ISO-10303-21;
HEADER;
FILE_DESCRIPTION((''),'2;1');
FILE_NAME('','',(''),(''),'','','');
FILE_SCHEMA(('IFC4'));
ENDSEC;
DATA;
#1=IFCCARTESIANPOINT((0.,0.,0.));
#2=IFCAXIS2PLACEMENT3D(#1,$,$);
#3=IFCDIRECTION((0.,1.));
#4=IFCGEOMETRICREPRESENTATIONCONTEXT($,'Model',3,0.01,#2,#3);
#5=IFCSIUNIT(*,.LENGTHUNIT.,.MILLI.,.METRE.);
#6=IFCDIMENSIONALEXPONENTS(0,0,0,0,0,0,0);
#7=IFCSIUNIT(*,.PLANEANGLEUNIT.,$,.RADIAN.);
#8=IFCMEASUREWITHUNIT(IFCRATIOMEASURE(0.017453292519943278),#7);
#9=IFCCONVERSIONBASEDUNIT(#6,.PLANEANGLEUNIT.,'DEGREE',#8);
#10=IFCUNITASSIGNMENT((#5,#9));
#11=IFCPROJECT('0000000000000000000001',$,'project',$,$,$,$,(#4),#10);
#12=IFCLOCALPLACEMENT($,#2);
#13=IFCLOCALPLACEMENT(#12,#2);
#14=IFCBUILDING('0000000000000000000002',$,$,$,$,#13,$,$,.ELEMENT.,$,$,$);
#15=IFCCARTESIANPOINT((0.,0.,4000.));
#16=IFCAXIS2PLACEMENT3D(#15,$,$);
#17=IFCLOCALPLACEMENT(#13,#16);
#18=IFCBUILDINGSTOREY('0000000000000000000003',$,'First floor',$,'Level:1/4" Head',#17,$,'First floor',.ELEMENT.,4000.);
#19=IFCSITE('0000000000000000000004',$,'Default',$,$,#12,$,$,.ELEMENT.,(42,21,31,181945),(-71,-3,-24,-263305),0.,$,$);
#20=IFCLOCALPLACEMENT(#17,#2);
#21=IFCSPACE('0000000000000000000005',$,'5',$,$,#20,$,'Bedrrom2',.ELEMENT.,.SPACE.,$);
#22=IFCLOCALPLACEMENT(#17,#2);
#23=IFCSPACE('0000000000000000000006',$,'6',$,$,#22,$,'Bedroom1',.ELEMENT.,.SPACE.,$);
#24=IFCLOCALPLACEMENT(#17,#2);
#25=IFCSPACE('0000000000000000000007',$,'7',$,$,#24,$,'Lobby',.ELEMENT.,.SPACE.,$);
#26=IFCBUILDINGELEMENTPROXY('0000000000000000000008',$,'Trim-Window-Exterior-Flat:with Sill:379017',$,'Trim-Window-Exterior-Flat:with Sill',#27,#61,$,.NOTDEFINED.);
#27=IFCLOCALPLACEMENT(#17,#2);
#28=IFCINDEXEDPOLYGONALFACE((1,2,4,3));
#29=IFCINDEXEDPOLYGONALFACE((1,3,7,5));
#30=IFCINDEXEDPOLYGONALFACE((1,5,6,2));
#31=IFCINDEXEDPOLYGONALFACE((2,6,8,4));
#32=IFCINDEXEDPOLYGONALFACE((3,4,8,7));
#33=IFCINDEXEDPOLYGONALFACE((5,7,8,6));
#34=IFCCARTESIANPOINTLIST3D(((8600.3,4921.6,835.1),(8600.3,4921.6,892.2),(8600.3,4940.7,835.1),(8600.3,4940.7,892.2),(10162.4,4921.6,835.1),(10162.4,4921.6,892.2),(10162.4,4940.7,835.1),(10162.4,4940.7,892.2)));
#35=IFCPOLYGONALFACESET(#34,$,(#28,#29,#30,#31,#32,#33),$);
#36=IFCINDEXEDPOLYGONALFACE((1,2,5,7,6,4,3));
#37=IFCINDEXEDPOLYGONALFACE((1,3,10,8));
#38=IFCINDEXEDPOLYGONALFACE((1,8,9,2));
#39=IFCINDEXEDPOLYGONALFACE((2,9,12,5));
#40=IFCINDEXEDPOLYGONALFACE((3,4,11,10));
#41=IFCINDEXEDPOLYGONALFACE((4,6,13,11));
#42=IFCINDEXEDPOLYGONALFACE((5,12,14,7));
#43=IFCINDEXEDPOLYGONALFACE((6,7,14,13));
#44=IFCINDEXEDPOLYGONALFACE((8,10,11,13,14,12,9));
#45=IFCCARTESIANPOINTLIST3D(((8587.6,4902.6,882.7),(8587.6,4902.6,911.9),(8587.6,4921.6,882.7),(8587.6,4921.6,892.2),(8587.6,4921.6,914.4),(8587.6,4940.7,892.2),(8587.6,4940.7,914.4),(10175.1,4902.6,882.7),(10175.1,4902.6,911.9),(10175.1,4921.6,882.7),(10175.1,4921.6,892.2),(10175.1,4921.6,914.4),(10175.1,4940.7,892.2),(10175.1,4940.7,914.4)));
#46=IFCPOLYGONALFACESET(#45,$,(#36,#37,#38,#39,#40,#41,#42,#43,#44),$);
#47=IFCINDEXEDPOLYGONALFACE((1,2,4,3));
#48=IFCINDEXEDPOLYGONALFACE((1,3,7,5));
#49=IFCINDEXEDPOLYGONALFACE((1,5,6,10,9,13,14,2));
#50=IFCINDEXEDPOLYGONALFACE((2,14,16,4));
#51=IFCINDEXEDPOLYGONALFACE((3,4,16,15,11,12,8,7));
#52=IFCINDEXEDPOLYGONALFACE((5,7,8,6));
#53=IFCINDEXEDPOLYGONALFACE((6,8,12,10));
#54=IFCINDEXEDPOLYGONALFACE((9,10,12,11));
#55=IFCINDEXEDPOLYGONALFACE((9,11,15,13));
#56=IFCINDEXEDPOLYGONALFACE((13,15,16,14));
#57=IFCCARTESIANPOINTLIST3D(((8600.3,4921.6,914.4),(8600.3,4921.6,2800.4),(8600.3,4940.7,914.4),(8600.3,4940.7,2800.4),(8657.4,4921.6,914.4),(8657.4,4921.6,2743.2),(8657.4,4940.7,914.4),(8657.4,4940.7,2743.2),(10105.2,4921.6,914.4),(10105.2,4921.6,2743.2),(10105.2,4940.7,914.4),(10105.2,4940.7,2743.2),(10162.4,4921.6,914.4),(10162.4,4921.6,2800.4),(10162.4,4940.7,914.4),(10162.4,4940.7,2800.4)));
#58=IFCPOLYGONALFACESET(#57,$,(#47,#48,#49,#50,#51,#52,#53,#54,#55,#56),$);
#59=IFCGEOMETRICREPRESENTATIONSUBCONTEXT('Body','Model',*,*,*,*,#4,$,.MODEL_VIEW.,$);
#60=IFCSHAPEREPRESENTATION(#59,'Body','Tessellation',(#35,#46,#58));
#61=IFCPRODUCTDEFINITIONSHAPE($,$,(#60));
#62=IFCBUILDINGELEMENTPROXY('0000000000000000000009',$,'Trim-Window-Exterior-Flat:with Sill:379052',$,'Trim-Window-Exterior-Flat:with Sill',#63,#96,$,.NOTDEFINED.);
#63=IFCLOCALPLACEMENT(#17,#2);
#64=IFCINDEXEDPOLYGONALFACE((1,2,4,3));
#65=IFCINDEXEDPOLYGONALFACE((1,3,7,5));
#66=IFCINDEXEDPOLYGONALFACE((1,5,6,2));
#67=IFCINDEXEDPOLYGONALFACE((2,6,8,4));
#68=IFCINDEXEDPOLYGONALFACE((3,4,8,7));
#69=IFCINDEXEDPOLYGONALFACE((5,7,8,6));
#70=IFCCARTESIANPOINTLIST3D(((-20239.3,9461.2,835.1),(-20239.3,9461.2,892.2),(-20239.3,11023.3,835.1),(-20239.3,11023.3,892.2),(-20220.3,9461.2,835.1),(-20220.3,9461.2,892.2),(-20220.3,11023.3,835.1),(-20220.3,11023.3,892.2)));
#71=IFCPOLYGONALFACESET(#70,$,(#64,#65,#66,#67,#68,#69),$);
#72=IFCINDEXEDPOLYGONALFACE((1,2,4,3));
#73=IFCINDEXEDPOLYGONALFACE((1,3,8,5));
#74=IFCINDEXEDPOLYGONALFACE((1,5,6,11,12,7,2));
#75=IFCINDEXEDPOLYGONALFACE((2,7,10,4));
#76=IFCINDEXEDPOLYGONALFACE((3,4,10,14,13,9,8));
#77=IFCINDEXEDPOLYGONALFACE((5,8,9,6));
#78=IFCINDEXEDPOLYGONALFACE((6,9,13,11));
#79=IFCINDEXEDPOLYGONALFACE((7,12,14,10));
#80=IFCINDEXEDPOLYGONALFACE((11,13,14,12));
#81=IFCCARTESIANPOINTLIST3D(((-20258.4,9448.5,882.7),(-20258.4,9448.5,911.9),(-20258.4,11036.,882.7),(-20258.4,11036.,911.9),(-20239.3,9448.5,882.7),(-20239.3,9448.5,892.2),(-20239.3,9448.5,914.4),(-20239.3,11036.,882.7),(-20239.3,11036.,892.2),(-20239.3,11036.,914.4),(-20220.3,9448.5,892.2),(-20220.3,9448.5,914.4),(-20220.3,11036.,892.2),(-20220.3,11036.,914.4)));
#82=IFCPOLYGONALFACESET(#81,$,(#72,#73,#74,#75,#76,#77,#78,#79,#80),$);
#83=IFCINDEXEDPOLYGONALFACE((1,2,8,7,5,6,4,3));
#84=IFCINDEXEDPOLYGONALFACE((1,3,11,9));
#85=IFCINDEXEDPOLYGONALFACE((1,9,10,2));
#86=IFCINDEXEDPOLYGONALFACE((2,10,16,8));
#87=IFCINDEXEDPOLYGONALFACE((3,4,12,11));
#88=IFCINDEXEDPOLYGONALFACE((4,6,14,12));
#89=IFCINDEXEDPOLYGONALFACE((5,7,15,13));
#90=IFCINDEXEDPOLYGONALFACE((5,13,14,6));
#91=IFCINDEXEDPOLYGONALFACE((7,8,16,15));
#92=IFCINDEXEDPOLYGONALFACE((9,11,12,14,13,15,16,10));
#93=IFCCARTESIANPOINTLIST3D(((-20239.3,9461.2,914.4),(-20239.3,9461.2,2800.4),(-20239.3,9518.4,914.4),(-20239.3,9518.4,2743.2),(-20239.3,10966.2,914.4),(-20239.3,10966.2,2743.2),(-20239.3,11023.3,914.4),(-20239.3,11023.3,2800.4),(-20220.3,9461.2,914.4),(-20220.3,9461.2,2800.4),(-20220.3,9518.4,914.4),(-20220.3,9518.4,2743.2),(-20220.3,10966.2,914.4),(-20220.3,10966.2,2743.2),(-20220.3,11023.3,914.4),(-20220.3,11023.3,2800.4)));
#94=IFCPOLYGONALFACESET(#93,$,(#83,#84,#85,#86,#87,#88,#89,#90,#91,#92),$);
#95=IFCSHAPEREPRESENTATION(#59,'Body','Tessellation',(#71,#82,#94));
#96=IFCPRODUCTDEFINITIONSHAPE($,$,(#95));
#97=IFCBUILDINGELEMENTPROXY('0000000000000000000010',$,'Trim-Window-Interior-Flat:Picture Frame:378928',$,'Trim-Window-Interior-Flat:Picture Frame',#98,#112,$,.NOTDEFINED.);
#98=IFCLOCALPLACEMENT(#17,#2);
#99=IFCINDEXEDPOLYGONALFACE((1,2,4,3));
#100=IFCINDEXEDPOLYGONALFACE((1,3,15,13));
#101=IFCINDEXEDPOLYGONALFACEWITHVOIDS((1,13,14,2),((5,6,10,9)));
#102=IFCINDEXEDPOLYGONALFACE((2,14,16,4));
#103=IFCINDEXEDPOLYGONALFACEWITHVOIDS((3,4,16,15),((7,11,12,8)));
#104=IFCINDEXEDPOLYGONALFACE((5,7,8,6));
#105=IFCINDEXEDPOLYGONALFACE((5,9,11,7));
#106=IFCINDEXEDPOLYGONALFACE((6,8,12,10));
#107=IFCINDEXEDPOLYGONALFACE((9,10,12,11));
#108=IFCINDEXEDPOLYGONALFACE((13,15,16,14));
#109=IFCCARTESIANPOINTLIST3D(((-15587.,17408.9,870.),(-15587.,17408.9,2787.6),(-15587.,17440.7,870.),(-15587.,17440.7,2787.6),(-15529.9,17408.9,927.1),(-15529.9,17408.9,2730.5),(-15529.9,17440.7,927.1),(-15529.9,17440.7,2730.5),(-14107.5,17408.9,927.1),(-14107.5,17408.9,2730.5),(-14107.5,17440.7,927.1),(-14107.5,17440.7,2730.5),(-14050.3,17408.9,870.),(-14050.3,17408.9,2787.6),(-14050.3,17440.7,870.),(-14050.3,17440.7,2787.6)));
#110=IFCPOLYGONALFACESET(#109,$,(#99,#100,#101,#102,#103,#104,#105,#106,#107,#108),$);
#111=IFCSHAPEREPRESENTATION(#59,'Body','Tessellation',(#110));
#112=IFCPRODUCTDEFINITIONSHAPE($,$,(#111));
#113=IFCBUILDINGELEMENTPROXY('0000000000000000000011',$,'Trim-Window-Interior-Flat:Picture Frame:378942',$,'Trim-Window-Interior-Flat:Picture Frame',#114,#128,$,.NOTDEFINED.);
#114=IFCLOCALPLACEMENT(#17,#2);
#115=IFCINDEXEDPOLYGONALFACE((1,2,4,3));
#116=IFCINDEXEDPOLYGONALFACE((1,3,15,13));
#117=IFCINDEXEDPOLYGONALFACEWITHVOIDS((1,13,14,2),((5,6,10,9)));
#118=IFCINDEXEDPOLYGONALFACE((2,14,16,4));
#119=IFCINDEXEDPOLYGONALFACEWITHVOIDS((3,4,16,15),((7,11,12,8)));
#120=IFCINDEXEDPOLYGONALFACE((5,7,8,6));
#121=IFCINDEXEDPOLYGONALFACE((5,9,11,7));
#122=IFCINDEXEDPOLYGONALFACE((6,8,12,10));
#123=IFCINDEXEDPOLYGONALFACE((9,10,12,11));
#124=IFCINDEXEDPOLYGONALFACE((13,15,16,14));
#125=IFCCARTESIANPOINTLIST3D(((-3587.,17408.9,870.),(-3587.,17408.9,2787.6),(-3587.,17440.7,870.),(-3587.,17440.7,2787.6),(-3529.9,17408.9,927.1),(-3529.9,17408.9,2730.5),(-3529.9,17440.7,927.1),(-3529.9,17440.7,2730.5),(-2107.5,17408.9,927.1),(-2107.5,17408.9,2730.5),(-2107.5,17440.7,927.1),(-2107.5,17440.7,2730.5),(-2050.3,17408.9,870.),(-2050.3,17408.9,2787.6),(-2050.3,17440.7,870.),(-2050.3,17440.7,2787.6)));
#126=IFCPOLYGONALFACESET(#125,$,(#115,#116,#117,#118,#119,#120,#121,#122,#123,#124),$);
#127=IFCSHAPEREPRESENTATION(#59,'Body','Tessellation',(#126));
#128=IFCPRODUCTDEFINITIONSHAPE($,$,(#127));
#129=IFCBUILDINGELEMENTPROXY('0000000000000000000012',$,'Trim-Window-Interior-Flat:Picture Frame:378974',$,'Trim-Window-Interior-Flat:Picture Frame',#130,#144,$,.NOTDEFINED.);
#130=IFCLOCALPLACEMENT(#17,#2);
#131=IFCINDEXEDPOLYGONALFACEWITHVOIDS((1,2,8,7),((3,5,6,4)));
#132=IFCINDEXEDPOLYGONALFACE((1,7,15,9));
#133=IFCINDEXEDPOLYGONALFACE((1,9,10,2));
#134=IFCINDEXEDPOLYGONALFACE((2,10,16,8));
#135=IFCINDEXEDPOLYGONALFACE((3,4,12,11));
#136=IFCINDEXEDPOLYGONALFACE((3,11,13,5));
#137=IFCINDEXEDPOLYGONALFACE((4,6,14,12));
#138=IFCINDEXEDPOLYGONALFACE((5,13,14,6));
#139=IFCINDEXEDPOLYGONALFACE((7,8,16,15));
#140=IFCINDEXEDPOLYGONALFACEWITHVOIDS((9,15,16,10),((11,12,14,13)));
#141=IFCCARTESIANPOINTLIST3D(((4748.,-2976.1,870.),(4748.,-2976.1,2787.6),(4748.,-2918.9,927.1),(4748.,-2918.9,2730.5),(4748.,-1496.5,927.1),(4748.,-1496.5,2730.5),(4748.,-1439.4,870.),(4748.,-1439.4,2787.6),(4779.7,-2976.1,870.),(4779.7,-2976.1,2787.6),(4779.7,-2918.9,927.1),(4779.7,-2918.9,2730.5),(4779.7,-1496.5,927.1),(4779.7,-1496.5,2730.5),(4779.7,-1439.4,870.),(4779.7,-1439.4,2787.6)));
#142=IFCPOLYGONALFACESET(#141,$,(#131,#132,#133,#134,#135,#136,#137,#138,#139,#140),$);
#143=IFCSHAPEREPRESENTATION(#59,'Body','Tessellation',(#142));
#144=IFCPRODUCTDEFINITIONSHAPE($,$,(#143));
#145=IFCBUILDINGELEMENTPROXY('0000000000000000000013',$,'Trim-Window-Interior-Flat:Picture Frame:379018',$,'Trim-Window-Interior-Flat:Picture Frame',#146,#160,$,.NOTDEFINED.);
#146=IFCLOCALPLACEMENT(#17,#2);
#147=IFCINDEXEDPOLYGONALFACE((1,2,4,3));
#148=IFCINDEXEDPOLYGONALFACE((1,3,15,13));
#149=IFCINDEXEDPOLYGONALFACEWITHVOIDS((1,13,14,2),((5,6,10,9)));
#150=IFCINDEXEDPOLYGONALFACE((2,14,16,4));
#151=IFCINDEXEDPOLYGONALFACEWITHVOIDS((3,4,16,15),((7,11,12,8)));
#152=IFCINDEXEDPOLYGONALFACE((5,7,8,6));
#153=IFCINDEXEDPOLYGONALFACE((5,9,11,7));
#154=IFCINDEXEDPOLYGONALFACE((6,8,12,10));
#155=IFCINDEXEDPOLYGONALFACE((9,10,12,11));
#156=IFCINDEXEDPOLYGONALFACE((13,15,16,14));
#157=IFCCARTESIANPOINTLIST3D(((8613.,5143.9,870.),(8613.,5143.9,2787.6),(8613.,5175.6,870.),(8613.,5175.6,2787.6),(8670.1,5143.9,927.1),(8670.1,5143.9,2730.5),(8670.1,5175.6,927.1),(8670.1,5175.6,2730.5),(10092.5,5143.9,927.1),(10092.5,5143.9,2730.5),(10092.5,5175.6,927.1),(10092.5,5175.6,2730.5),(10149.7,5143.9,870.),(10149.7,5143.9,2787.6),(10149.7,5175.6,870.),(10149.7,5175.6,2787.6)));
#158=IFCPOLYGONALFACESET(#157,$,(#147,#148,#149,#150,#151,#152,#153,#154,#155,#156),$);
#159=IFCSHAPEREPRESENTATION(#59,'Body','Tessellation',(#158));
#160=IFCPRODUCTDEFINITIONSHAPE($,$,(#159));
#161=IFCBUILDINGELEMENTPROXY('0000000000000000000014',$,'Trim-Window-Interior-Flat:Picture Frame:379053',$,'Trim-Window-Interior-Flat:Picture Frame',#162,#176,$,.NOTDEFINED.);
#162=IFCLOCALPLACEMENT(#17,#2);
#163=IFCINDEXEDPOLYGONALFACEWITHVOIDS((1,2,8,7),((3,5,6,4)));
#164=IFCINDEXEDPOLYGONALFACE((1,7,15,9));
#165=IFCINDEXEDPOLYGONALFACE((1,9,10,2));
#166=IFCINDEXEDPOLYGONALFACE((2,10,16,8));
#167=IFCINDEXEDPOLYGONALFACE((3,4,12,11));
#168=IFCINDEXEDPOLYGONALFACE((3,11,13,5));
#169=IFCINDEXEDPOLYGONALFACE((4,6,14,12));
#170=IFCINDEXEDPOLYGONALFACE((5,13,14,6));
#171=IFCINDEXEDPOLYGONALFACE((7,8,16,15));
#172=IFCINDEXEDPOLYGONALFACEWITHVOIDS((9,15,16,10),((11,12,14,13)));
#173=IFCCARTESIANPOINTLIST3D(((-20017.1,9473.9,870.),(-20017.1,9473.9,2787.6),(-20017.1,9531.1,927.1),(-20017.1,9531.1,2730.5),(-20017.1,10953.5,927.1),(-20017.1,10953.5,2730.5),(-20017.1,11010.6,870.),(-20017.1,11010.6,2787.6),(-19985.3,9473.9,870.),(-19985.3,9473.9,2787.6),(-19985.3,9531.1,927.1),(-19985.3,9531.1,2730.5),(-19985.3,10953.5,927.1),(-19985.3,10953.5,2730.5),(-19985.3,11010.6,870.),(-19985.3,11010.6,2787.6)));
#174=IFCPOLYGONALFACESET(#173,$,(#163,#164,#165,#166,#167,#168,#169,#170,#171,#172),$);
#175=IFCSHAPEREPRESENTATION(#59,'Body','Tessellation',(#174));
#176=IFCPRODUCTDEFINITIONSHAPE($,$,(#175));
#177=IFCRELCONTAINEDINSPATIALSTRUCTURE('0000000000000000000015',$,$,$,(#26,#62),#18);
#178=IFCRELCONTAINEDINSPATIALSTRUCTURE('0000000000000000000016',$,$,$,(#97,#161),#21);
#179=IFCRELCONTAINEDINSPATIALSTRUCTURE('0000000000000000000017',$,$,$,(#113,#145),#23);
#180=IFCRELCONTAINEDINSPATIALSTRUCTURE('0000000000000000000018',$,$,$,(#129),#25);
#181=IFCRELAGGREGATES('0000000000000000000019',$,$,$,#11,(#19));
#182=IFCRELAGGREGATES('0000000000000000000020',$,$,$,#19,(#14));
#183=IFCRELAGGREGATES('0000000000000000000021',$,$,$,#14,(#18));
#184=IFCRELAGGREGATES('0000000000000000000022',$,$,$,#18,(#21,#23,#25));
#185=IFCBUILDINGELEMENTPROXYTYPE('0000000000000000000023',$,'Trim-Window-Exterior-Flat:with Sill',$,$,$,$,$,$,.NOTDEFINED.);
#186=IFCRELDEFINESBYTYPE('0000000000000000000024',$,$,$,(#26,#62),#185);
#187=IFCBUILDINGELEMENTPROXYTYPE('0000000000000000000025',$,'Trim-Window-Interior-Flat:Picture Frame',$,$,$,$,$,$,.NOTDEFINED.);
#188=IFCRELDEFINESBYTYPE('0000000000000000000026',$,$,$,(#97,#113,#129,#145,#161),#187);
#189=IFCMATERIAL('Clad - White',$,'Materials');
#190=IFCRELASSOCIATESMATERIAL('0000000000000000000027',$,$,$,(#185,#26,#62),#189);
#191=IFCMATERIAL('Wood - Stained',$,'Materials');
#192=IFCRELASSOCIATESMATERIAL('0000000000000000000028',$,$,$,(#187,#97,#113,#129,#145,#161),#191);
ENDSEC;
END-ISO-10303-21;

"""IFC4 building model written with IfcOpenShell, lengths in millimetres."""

from ifc_helpers import new_model, entity, si_unit, converted_unit, direction, frame, origin, place, context, subcontext, project, spatial, indexed_curve, outline, extrude, source, transform, mapped, material, type_object, type_shapes, element, save


model = new_model("IFC4")

# Units and contexts
model_context = context("Model", 3, precision=0.01, world=origin(), true_north=direction((0.0, 1.0)))
body_context = subcontext(model_context, "Body", "Model", "MODEL_VIEW")
ifc_project = project(units=[si_unit("LENGTHUNIT", "METRE", prefix="MILLI"), converted_unit("PLANEANGLEUNIT", "DEGREE", entity("IfcRatioMeasure", 0.017453292519943278), si_unit("PLANEANGLEUNIT", "RADIAN"), dimensions=[0, 0, 0, 0, 0, 0, 0])], contexts=[model_context])

# Site, building, storey
site_placement = place(None, origin())
site = spatial("IfcSite", under=ifc_project, at=site_placement, Name="Default", CompositionType="ELEMENT", RefLatitude=(42, 21, 31, 181945), RefLongitude=(-71, -3, -24, -263305), RefElevation=0.0)
building_placement = place(site_placement, origin())
building = spatial("IfcBuilding", under=site, at=building_placement, CompositionType="ELEMENT")
storey_placement = place(building_placement, frame((0.0, 0.0, 4000.0)))
storey = spatial("IfcBuildingStorey", under=building, at=storey_placement, Name="First floor", ObjectType="Level:1/4\" Head", LongName="First floor", CompositionType="ELEMENT", Elevation=4000.0)

# Building element proxies
ifc_material_1 = material(Name="Clad - White", Category="Materials")
ifc_material_2 = material(Name="Wood - Stained", Category="Materials")
building_element_proxy_type_1 = type_object("IfcBuildingElementProxyType", Name="Trim-Window-Exterior-Flat:with Sill", PredefinedType="NOTDEFINED", material=ifc_material_1)
shared_shape_1 = source(origin(), body_context, "Body", "SweptSolid", [
    extrude(outline(indexed_curve([(-781.0, -28.6), (781.0, -28.6), (781.0, 28.6), (-781.0, 28.6), (-781.0, -28.6)], self_intersect=False)), frame((0.0, -1879.6, 0.0), z_axis=(0.0, 0.0, 1.0), x_axis=(-1.0, 0.0, 0.0)), (0.0, 0.0, 1.0), 19.0),
    extrude(outline(indexed_curve([(-19.0, -16.0), (0.0, -16.0), (0.0, -6.4), (19.0, -6.4), (19.0, 15.8), (0.0, 15.8), (-19.0, 13.3), (-19.0, -16.0)], self_intersect=False)), frame((-793.7, -1844.6, 19.0), z_axis=(1.0, 0.0, 0.0), x_axis=(0.0, 0.0, -1.0)), (0.0, 0.0, 1.0), 1587.5),
    extrude(outline(indexed_curve([(-957.3, -781.0), (928.7, -781.0), (928.7, -723.9), (-900.1, -723.9), (-900.1, 723.9), (928.7, 723.9), (928.7, 781.0), (-957.3, 781.0), (-957.3, -781.0)], self_intersect=False)), frame((0.0, -900.1, 0.0), z_axis=(0.0, 0.0, 1.0), x_axis=(0.0, -1.0, 0.0)), (0.0, 0.0, 1.0), 19.0),
])
type_shapes(building_element_proxy_type_1, [shared_shape_1])
for number, where, z_axis, x_axis, name in (
    (1, (9381.3, 4940.7, 2743.2), (0.0, -1.0, 0.0), (1.0, 0.0, 0.0), "Trim-Window-Exterior-Flat:with Sill:379017"),
    (2, (-20220.3, 10242.3, 2743.2), (-1.0, 0.0, 0.0), (0.0, -1.0, 0.0), "Trim-Window-Exterior-Flat:with Sill:379052"),
):
    element("IfcBuildingElementProxy", number, at=place(storey_placement, frame(where, z_axis=z_axis, x_axis=x_axis)), inside=storey, type_object=building_element_proxy_type_1, material=ifc_material_1, Name=name, ObjectType="Trim-Window-Exterior-Flat:with Sill", PredefinedType="NOTDEFINED", context=body_context, shape_type="MappedRepresentation", body=[
        mapped(shared_shape_1, transform((0.0, 0.0, 0.0), scale=1.0)),
    ])

# Shared definitions
space_1_placement = place(storey_placement, origin())
space_1 = spatial("IfcSpace", under=storey, at=space_1_placement, Name="5", LongName="Bedrrom2", CompositionType="ELEMENT", PredefinedType="SPACE")

# Building element proxy
building_element_proxy_type_2 = type_object("IfcBuildingElementProxyType", Name="Trim-Window-Interior-Flat:Picture Frame", PredefinedType="NOTDEFINED", material=ifc_material_2)
shared_shape_2 = source(origin(), body_context, "Body", "SweptSolid", [
    extrude(outline(indexed_curve([(-768.3, -958.8), (768.3, -958.8), (768.3, 958.8), (-768.3, 958.8), (-768.3, -958.8)], self_intersect=False), holes=[indexed_curve([(-711.2, -901.7), (-711.2, 901.7), (711.2, 901.7), (711.2, -901.7), (-711.2, -901.7)], self_intersect=False)]), frame((0.0, -914.4, 0.0), z_axis=(0.0, 0.0, 1.0), x_axis=(-1.0, 0.0, 0.0)), (0.0, 0.0, 1.0), 31.7),
])
type_shapes(building_element_proxy_type_2, [shared_shape_2])
proxy_1_placement = place(space_1_placement, frame((-14818.7, 17440.7, 2743.2), z_axis=(0.0, -1.0, 0.0), x_axis=(1.0, 0.0, 0.0)))
element("IfcBuildingElementProxy", 3, at=proxy_1_placement, inside=space_1, type_object=building_element_proxy_type_2, material=ifc_material_2, Name="Trim-Window-Interior-Flat:Picture Frame:378928", ObjectType="Trim-Window-Interior-Flat:Picture Frame", PredefinedType="NOTDEFINED", context=body_context, shape_type="MappedRepresentation", body=[
    mapped(shared_shape_2, transform((0.0, 0.0, 0.0), scale=1.0)),
])

# Shared definitions
space_2_placement = place(storey_placement, origin())
space_2 = spatial("IfcSpace", under=storey, at=space_2_placement, Name="6", LongName="Bedroom1", CompositionType="ELEMENT", PredefinedType="SPACE")

# Building element proxy
proxy_2_placement = place(space_2_placement, frame((-2818.7, 17440.7, 2743.2), z_axis=(0.0, -1.0, 0.0), x_axis=(1.0, 0.0, 0.0)))
element("IfcBuildingElementProxy", 4, at=proxy_2_placement, inside=space_2, type_object=building_element_proxy_type_2, material=ifc_material_2, Name="Trim-Window-Interior-Flat:Picture Frame:378942", ObjectType="Trim-Window-Interior-Flat:Picture Frame", PredefinedType="NOTDEFINED", context=body_context, shape_type="MappedRepresentation", body=[
    mapped(shared_shape_2, transform((0.0, 0.0, 0.0), scale=1.0)),
])

# Shared definitions
space_3_placement = place(storey_placement, origin())
space_3 = spatial("IfcSpace", under=storey, at=space_3_placement, Name="7", LongName="Lobby", CompositionType="ELEMENT", PredefinedType="SPACE")

# Building element proxies
proxy_3_placement = place(space_3_placement, frame((4779.7, -2207.7, 2743.2), z_axis=(-1.0, 0.0, 0.0), x_axis=(0.0, -1.0, 0.0)))
element("IfcBuildingElementProxy", 5, at=proxy_3_placement, inside=space_3, type_object=building_element_proxy_type_2, material=ifc_material_2, Name="Trim-Window-Interior-Flat:Picture Frame:378974", ObjectType="Trim-Window-Interior-Flat:Picture Frame", PredefinedType="NOTDEFINED", context=body_context, shape_type="MappedRepresentation", body=[
    mapped(shared_shape_2, transform((0.0, 0.0, 0.0), scale=1.0)),
])
proxy_4_placement = place(space_2_placement, frame((9381.3, 5143.9, 2743.2), z_axis=(0.0, 1.0, 0.0), x_axis=(-1.0, 0.0, 0.0)))
element("IfcBuildingElementProxy", 6, at=proxy_4_placement, inside=space_2, type_object=building_element_proxy_type_2, material=ifc_material_2, Name="Trim-Window-Interior-Flat:Picture Frame:379018", ObjectType="Trim-Window-Interior-Flat:Picture Frame", PredefinedType="NOTDEFINED", context=body_context, shape_type="MappedRepresentation", body=[
    mapped(shared_shape_2, transform((0.0, 0.0, 0.0), scale=1.0)),
])
proxy_5_placement = place(space_1_placement, frame((-20017.1, 10242.3, 2743.2), z_axis=(1.0, 0.0, 0.0), x_axis=(0.0, 1.0, 0.0)))
element("IfcBuildingElementProxy", 7, at=proxy_5_placement, inside=space_1, type_object=building_element_proxy_type_2, material=ifc_material_2, Name="Trim-Window-Interior-Flat:Picture Frame:379053", ObjectType="Trim-Window-Interior-Flat:Picture Frame", PredefinedType="NOTDEFINED", context=body_context, shape_type="MappedRepresentation", body=[
    mapped(shared_shape_2, transform((0.0, 0.0, 0.0), scale=1.0)),
])

save(model, "model.ifc")
